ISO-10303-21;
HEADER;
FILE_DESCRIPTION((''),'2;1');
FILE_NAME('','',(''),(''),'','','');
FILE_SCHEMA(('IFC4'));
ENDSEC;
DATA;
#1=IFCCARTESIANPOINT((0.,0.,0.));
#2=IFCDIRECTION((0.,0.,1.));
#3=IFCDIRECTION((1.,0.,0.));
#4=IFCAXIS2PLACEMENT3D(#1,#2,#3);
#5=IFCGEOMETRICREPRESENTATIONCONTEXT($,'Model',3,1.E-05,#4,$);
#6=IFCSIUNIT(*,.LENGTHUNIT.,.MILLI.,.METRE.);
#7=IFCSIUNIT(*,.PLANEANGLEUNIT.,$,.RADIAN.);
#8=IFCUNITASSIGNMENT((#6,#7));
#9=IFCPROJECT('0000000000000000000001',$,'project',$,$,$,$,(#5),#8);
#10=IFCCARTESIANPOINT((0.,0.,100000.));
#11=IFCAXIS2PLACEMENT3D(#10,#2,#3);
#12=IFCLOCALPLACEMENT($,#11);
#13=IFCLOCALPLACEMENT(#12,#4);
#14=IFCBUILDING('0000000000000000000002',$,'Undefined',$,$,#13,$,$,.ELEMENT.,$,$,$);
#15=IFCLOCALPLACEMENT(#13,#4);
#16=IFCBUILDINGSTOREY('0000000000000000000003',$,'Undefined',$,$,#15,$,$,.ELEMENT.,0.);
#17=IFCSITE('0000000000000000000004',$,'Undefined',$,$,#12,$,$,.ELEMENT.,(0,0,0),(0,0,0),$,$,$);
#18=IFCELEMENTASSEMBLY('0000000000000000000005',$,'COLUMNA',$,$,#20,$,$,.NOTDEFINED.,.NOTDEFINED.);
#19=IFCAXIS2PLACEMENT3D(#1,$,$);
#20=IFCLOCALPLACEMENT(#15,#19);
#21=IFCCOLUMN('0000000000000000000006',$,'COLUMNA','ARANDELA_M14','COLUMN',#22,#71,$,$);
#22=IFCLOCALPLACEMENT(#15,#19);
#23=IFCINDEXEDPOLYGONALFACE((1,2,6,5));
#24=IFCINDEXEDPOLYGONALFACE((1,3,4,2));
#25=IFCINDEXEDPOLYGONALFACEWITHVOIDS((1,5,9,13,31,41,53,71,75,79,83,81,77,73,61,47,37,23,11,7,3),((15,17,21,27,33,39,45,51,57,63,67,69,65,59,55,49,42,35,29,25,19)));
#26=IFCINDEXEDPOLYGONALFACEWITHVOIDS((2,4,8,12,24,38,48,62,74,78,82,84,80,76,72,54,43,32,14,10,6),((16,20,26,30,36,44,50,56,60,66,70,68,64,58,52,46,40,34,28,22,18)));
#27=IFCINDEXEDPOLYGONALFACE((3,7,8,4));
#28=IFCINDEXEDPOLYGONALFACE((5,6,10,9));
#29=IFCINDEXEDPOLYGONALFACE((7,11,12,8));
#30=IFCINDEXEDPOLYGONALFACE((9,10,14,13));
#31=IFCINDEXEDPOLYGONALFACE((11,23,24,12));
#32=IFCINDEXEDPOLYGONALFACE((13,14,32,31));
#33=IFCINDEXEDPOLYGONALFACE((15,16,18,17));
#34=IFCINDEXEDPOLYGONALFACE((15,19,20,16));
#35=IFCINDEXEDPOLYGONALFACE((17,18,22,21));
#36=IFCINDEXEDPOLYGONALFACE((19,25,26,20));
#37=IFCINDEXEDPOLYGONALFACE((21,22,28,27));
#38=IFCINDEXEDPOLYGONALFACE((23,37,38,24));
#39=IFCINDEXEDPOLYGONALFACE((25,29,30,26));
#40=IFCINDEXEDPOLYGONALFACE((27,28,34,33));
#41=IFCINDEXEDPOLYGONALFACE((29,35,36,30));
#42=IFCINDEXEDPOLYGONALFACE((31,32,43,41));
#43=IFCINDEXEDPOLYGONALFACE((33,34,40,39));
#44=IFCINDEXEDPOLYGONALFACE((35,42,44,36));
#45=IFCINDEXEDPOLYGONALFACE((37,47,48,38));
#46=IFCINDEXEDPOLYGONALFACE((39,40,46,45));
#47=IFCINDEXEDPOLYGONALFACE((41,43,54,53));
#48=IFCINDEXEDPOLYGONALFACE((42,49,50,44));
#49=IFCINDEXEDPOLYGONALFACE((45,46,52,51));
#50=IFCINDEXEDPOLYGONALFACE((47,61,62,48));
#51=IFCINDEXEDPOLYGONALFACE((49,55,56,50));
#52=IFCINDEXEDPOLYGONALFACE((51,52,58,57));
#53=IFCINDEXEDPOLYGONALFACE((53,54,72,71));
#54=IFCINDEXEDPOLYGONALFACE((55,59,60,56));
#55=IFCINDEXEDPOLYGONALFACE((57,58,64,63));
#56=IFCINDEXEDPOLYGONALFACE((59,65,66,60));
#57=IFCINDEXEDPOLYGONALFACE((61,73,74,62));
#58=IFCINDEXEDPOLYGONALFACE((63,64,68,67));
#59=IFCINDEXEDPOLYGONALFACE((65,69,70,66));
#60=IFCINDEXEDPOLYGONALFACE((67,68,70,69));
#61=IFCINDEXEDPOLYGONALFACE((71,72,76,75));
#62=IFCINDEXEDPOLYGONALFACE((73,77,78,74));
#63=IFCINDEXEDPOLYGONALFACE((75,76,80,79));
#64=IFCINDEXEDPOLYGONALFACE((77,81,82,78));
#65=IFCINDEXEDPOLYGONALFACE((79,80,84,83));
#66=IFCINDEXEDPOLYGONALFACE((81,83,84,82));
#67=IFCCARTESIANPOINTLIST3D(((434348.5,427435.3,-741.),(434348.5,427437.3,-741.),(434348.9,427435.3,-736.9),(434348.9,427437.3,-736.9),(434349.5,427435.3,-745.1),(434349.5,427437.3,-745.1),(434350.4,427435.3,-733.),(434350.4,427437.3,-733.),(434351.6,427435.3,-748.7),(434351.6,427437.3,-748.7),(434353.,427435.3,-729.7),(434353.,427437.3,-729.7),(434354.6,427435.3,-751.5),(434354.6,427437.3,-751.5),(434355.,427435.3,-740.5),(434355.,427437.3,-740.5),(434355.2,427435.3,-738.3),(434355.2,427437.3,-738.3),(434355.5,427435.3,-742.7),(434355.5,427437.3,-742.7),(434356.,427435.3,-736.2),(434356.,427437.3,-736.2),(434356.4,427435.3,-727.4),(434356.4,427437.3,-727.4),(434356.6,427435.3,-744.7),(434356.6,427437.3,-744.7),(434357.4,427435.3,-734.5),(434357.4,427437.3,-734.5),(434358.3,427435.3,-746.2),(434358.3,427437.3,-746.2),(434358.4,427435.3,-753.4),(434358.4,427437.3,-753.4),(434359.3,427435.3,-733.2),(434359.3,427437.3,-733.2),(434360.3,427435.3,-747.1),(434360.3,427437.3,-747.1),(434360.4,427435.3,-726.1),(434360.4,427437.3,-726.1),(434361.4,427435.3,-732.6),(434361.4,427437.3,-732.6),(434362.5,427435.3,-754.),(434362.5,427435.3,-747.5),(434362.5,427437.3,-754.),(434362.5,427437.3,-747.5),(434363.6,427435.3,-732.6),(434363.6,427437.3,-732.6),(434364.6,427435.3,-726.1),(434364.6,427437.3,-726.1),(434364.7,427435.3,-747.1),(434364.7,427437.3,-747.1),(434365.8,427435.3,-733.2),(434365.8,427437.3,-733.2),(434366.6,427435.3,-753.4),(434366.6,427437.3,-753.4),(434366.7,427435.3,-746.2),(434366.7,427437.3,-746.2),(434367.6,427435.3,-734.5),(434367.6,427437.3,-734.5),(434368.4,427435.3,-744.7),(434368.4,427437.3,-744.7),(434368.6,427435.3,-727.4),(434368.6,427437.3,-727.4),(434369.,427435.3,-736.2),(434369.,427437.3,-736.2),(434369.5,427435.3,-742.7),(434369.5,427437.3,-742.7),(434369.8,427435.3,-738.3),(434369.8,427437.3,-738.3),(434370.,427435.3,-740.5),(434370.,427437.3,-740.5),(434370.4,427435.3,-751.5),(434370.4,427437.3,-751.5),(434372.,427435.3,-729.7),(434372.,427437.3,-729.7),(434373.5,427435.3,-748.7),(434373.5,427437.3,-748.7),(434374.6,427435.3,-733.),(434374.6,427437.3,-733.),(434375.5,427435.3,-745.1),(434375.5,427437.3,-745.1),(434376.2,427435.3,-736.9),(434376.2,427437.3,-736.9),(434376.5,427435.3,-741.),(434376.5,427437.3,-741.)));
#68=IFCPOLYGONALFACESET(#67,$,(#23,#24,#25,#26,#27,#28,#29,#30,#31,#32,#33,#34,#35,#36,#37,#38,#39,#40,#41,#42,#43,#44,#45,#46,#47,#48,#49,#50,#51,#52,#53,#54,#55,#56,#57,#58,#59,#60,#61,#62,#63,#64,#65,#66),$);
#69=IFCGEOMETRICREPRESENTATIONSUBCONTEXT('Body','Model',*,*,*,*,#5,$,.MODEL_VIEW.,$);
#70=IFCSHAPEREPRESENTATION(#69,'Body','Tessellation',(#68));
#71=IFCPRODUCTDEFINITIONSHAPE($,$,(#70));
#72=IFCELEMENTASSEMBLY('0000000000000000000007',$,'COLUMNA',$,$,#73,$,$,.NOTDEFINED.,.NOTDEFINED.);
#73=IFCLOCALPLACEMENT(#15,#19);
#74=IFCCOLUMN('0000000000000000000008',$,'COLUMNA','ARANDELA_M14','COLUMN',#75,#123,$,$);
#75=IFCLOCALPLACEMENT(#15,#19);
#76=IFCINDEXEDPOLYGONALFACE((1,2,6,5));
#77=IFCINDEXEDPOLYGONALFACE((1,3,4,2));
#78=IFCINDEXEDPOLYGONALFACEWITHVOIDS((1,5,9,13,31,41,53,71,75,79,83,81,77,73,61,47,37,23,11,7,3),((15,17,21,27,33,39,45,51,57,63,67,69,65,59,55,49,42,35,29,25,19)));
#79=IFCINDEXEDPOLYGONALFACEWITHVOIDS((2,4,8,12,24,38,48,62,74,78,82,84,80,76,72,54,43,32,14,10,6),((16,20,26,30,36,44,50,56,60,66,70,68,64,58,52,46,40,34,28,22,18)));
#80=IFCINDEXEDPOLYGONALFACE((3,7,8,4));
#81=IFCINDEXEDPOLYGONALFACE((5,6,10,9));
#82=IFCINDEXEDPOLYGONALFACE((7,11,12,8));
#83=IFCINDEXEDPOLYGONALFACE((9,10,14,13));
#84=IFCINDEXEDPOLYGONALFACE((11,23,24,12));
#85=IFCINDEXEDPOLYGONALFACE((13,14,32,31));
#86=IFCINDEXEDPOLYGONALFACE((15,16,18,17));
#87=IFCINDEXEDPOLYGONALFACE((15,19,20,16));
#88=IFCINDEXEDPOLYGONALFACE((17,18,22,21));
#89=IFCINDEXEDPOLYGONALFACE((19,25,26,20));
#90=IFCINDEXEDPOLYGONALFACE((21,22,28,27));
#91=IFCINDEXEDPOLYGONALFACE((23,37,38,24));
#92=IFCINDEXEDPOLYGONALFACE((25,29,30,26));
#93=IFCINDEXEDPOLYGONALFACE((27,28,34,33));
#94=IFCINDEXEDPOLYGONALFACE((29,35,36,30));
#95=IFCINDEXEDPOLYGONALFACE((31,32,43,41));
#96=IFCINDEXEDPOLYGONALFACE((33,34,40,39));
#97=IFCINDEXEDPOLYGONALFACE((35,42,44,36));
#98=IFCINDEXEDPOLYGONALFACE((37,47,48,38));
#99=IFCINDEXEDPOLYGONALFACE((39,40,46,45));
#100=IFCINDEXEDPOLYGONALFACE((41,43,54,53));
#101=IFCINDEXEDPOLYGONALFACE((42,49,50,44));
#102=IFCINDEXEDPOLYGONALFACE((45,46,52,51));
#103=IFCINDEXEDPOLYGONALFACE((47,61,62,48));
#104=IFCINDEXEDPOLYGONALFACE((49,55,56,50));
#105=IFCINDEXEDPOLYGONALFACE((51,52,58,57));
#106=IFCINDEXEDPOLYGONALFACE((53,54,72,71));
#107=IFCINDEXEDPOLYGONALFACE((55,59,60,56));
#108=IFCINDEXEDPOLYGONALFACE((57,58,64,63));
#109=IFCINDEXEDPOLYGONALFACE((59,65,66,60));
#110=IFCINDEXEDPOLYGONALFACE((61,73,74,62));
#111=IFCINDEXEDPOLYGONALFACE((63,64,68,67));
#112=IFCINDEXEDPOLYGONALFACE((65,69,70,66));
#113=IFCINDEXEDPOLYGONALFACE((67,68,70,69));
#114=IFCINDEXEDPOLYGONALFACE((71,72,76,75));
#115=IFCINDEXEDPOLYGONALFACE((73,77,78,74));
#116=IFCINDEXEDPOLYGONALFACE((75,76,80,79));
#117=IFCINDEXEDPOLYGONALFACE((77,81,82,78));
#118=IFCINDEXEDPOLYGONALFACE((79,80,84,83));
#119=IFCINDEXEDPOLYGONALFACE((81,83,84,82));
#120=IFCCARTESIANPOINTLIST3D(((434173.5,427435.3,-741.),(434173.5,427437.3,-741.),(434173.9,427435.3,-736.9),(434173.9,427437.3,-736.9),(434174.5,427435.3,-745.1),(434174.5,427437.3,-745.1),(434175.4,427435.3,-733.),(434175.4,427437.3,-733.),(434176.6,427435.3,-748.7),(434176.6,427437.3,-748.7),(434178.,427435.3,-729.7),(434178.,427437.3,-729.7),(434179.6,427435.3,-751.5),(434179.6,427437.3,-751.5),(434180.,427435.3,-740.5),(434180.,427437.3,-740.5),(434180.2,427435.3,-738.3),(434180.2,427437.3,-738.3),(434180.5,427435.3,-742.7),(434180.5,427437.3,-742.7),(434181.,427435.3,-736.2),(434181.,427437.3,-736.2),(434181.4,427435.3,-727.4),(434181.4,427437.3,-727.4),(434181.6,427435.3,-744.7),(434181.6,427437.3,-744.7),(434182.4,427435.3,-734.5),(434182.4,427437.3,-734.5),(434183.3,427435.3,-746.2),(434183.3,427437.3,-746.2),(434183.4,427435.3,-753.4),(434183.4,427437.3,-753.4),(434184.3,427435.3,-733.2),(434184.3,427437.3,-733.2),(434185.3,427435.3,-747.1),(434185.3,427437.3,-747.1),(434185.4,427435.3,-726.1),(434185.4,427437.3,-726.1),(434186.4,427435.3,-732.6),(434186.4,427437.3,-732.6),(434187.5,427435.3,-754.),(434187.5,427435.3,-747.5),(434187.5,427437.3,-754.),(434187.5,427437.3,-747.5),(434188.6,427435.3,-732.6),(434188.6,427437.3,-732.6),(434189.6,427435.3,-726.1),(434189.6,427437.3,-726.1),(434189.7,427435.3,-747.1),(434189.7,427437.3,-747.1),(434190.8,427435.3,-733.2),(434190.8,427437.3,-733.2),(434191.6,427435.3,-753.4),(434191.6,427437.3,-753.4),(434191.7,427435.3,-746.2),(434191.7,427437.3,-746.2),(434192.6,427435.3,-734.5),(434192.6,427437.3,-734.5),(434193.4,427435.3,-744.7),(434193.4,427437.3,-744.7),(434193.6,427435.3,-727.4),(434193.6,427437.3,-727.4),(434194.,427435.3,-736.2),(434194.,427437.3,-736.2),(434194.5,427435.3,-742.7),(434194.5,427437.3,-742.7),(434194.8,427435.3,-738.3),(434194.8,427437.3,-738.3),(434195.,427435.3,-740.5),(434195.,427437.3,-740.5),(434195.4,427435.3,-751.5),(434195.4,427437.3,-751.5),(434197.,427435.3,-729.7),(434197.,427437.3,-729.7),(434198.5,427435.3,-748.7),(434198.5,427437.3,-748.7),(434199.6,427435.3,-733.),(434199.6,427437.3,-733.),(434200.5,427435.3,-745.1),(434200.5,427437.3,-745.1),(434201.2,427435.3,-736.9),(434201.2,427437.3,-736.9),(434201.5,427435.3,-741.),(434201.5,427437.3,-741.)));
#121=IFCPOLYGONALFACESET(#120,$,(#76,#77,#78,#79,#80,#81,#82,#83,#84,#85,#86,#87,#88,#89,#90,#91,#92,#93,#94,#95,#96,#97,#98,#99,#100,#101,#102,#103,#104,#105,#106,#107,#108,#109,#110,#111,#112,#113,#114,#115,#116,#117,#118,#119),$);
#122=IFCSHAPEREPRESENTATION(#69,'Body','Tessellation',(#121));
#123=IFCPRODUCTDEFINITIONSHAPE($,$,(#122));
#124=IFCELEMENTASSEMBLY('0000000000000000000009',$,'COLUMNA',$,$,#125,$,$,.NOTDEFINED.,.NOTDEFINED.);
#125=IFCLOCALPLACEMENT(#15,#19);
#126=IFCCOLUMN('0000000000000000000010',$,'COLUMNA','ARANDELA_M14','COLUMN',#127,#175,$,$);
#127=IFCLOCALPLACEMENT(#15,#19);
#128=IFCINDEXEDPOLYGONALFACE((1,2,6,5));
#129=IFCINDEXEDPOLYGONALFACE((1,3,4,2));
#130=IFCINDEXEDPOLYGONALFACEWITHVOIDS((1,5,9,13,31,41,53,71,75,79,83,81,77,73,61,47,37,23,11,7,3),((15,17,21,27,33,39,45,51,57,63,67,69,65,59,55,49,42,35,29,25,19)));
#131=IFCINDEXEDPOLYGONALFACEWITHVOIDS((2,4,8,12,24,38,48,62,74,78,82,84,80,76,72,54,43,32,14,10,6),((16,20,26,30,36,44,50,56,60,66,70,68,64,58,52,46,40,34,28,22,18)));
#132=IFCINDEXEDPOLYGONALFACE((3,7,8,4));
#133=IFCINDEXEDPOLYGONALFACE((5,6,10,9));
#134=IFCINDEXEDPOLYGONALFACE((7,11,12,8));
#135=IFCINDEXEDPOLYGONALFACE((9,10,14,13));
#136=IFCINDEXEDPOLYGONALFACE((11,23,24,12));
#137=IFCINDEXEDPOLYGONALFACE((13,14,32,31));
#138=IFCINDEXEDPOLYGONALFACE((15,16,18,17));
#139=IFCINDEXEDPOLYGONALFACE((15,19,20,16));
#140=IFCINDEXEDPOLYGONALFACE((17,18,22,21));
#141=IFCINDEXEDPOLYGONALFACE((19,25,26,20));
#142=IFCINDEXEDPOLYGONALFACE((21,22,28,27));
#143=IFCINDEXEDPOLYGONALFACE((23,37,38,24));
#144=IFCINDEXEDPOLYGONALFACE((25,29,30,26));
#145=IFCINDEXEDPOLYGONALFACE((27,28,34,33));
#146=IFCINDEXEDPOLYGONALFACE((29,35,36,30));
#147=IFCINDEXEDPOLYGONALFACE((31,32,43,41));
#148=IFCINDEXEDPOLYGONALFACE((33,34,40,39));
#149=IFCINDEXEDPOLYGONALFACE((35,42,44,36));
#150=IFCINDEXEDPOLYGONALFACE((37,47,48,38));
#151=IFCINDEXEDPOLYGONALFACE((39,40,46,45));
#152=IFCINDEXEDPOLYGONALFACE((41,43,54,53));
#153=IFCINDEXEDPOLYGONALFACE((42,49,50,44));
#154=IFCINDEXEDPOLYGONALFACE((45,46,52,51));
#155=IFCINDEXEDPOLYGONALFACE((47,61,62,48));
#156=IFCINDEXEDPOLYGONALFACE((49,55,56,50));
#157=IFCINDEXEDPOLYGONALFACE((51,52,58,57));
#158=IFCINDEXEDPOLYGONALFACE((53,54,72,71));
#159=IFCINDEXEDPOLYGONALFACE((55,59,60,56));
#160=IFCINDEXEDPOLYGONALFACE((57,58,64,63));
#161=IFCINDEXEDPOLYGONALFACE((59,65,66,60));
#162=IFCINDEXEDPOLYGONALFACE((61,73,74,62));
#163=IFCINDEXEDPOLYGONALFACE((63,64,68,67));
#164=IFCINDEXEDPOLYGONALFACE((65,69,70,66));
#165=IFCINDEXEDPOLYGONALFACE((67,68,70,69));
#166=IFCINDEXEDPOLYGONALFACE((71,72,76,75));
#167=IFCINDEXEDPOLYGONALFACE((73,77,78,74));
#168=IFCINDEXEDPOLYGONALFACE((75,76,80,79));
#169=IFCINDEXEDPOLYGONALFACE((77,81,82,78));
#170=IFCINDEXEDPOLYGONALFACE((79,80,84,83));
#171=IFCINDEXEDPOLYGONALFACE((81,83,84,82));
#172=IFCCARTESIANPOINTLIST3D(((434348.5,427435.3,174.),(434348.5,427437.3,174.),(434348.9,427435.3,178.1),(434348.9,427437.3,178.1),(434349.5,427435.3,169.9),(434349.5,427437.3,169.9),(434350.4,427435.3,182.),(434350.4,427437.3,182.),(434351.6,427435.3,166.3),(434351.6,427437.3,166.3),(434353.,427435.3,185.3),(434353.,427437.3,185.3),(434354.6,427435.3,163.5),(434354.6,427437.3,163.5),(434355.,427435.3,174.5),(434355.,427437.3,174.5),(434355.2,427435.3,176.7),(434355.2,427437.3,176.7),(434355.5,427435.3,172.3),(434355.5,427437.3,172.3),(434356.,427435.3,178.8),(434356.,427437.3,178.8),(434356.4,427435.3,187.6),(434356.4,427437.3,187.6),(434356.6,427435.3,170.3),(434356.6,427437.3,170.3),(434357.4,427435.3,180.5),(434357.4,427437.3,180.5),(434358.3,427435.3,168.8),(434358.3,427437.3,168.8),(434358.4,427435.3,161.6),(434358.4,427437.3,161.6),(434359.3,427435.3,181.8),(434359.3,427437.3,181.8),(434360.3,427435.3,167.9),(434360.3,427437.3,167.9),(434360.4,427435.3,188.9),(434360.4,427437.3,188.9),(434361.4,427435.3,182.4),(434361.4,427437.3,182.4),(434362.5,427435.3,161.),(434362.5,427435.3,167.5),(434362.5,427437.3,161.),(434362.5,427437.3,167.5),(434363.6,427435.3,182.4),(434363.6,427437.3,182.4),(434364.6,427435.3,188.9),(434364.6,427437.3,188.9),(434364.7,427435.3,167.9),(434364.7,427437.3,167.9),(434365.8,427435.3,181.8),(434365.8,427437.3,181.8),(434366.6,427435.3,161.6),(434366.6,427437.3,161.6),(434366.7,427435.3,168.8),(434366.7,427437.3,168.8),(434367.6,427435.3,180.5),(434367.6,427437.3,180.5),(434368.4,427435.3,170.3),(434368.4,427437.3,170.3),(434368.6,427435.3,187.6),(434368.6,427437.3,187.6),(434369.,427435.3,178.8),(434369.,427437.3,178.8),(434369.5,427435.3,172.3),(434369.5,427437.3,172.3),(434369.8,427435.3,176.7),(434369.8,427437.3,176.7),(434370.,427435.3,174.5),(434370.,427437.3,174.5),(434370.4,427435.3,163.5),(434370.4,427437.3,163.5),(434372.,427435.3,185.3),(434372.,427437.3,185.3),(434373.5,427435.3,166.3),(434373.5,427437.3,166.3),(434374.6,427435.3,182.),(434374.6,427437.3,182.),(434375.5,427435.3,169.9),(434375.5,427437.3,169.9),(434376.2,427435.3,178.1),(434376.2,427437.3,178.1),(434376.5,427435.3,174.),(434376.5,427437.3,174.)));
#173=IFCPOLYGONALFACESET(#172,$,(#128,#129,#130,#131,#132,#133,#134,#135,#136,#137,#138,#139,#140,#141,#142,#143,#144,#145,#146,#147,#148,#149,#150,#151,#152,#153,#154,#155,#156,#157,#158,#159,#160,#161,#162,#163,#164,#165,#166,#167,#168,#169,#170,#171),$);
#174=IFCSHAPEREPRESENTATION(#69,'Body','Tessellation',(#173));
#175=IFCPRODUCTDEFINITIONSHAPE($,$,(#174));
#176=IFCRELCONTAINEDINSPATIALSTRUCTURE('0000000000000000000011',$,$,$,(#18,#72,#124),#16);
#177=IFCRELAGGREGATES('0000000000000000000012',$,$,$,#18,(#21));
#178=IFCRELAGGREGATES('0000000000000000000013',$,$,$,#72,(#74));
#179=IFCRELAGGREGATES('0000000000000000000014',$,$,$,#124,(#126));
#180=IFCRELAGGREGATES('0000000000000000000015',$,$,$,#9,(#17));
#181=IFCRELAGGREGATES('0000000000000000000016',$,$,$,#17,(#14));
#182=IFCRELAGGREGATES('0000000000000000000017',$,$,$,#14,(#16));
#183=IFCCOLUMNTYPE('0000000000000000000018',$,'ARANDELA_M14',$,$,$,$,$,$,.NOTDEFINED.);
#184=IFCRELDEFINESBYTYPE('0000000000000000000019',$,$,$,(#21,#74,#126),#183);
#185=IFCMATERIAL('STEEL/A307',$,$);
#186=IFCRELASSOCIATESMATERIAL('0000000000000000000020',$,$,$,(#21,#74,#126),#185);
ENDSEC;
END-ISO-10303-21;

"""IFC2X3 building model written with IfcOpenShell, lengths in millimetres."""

from ifc_helpers import new_model, si_unit, frame, origin_with_axes, origin_2d_with_axis, place, context, subcontext, project, spatial, hollow_circle, extrude, material, type_object, element, aggregate, save


model = new_model("IFC2X3")

# Units and contexts
model_context = context("Model", 3, precision=1e-05, world=origin_with_axes())
body_context = subcontext(model_context, "Body", "Model", "MODEL_VIEW")
ifc_project = project(units=[si_unit("LENGTHUNIT", "METRE", prefix="MILLI"), si_unit("PLANEANGLEUNIT", "RADIAN")], contexts=[model_context])

# Site, building, storey
site_placement = place(None, frame((0.0, 0.0, 100000.0), z_axis=(0.0, 0.0, 1.0), x_axis=(1.0, 0.0, 0.0)))
site = spatial("IfcSite", under=ifc_project, at=site_placement, Name="Undefined", CompositionType="ELEMENT", RefLatitude=(0, 0, 0), RefLongitude=(0, 0, 0))
building_placement = place(site_placement, origin_with_axes())
building = spatial("IfcBuilding", under=site, at=building_placement, Name="Undefined", CompositionType="ELEMENT")
storey_placement = place(building_placement, origin_with_axes())
storey = spatial("IfcBuildingStorey", under=building, at=storey_placement, Name="Undefined", CompositionType="ELEMENT", Elevation=0.0)

# Element assemblies, columns
assembly_1_placement = place(storey_placement, origin_with_axes())
assembly_1 = element("IfcElementAssembly", 1, at=assembly_1_placement, inside=storey, Name="COLUMNA", AssemblyPlace="NOTDEFINED", PredefinedType="NOTDEFINED")
ifc_material_1 = material(Name="STEEL/A307")
column_type_1 = type_object("IfcColumnType", Name="ARANDELA_M14", PredefinedType="NOTDEFINED")
column_1_placement = place(assembly_1_placement, frame((434362.5, 427437.3, -740.0), z_axis=(0.0, -1.0, 0.000285), x_axis=(-1.0, 0.0, 0.0)))
column_1 = element("IfcColumn", 2, at=column_1_placement, type_object=column_type_1, material=ifc_material_1, Name="COLUMNA", Description="ARANDELA_M14", ObjectType="COLUMN", context=body_context, shape_type="SweptSolid", body=[
    extrude(hollow_circle(Radius=14.0, WallThickness=6.5, at=origin_2d_with_axis()), frame((0.0, 0.0, 2.0), z_axis=(0.0, 0.0, -1.0), x_axis=(0.0, 1.0, 0.0)), (0.0, 0.0, 1.0), 2.0),
])
aggregate(assembly_1, [column_1])
assembly_2_placement = place(storey_placement, origin_with_axes())
assembly_2 = element("IfcElementAssembly", 3, at=assembly_2_placement, inside=storey, Name="COLUMNA", AssemblyPlace="NOTDEFINED", PredefinedType="NOTDEFINED")
column_2_placement = place(assembly_2_placement, frame((434187.5, 427437.3, -740.0), z_axis=(0.0, -1.0, 0.000285), x_axis=(-1.0, 0.0, 0.0)))
column_2 = element("IfcColumn", 4, at=column_2_placement, type_object=column_type_1, material=ifc_material_1, Name="COLUMNA", Description="ARANDELA_M14", ObjectType="COLUMN", context=body_context, shape_type="SweptSolid", body=[
    extrude(hollow_circle(Radius=14.0, WallThickness=6.5, at=origin_2d_with_axis()), frame((0.0, 0.0, 2.0), z_axis=(0.0, 0.0, -1.0), x_axis=(0.0, 1.0, 0.0)), (0.0, 0.0, 1.0), 2.0),
])
aggregate(assembly_2, [column_2])
assembly_3_placement = place(storey_placement, origin_with_axes())
assembly_3 = element("IfcElementAssembly", 5, at=assembly_3_placement, inside=storey, Name="COLUMNA", AssemblyPlace="NOTDEFINED", PredefinedType="NOTDEFINED")
column_3_placement = place(assembly_3_placement, frame((434362.5, 427437.3, 175.0), z_axis=(0.0, -1.0, 0.000285), x_axis=(-1.0, 0.0, 0.0)))
column_3 = element("IfcColumn", 6, at=column_3_placement, type_object=column_type_1, material=ifc_material_1, Name="COLUMNA", Description="ARANDELA_M14", ObjectType="COLUMN", context=body_context, shape_type="SweptSolid", body=[
    extrude(hollow_circle(Radius=14.0, WallThickness=6.5, at=origin_2d_with_axis()), frame((0.0, 0.0, 2.0), z_axis=(0.0, 0.0, -1.0), x_axis=(0.0, 1.0, 0.0)), (0.0, 0.0, 1.0), 2.0),
])
aggregate(assembly_3, [column_3])

save(model, "model.ifc")
